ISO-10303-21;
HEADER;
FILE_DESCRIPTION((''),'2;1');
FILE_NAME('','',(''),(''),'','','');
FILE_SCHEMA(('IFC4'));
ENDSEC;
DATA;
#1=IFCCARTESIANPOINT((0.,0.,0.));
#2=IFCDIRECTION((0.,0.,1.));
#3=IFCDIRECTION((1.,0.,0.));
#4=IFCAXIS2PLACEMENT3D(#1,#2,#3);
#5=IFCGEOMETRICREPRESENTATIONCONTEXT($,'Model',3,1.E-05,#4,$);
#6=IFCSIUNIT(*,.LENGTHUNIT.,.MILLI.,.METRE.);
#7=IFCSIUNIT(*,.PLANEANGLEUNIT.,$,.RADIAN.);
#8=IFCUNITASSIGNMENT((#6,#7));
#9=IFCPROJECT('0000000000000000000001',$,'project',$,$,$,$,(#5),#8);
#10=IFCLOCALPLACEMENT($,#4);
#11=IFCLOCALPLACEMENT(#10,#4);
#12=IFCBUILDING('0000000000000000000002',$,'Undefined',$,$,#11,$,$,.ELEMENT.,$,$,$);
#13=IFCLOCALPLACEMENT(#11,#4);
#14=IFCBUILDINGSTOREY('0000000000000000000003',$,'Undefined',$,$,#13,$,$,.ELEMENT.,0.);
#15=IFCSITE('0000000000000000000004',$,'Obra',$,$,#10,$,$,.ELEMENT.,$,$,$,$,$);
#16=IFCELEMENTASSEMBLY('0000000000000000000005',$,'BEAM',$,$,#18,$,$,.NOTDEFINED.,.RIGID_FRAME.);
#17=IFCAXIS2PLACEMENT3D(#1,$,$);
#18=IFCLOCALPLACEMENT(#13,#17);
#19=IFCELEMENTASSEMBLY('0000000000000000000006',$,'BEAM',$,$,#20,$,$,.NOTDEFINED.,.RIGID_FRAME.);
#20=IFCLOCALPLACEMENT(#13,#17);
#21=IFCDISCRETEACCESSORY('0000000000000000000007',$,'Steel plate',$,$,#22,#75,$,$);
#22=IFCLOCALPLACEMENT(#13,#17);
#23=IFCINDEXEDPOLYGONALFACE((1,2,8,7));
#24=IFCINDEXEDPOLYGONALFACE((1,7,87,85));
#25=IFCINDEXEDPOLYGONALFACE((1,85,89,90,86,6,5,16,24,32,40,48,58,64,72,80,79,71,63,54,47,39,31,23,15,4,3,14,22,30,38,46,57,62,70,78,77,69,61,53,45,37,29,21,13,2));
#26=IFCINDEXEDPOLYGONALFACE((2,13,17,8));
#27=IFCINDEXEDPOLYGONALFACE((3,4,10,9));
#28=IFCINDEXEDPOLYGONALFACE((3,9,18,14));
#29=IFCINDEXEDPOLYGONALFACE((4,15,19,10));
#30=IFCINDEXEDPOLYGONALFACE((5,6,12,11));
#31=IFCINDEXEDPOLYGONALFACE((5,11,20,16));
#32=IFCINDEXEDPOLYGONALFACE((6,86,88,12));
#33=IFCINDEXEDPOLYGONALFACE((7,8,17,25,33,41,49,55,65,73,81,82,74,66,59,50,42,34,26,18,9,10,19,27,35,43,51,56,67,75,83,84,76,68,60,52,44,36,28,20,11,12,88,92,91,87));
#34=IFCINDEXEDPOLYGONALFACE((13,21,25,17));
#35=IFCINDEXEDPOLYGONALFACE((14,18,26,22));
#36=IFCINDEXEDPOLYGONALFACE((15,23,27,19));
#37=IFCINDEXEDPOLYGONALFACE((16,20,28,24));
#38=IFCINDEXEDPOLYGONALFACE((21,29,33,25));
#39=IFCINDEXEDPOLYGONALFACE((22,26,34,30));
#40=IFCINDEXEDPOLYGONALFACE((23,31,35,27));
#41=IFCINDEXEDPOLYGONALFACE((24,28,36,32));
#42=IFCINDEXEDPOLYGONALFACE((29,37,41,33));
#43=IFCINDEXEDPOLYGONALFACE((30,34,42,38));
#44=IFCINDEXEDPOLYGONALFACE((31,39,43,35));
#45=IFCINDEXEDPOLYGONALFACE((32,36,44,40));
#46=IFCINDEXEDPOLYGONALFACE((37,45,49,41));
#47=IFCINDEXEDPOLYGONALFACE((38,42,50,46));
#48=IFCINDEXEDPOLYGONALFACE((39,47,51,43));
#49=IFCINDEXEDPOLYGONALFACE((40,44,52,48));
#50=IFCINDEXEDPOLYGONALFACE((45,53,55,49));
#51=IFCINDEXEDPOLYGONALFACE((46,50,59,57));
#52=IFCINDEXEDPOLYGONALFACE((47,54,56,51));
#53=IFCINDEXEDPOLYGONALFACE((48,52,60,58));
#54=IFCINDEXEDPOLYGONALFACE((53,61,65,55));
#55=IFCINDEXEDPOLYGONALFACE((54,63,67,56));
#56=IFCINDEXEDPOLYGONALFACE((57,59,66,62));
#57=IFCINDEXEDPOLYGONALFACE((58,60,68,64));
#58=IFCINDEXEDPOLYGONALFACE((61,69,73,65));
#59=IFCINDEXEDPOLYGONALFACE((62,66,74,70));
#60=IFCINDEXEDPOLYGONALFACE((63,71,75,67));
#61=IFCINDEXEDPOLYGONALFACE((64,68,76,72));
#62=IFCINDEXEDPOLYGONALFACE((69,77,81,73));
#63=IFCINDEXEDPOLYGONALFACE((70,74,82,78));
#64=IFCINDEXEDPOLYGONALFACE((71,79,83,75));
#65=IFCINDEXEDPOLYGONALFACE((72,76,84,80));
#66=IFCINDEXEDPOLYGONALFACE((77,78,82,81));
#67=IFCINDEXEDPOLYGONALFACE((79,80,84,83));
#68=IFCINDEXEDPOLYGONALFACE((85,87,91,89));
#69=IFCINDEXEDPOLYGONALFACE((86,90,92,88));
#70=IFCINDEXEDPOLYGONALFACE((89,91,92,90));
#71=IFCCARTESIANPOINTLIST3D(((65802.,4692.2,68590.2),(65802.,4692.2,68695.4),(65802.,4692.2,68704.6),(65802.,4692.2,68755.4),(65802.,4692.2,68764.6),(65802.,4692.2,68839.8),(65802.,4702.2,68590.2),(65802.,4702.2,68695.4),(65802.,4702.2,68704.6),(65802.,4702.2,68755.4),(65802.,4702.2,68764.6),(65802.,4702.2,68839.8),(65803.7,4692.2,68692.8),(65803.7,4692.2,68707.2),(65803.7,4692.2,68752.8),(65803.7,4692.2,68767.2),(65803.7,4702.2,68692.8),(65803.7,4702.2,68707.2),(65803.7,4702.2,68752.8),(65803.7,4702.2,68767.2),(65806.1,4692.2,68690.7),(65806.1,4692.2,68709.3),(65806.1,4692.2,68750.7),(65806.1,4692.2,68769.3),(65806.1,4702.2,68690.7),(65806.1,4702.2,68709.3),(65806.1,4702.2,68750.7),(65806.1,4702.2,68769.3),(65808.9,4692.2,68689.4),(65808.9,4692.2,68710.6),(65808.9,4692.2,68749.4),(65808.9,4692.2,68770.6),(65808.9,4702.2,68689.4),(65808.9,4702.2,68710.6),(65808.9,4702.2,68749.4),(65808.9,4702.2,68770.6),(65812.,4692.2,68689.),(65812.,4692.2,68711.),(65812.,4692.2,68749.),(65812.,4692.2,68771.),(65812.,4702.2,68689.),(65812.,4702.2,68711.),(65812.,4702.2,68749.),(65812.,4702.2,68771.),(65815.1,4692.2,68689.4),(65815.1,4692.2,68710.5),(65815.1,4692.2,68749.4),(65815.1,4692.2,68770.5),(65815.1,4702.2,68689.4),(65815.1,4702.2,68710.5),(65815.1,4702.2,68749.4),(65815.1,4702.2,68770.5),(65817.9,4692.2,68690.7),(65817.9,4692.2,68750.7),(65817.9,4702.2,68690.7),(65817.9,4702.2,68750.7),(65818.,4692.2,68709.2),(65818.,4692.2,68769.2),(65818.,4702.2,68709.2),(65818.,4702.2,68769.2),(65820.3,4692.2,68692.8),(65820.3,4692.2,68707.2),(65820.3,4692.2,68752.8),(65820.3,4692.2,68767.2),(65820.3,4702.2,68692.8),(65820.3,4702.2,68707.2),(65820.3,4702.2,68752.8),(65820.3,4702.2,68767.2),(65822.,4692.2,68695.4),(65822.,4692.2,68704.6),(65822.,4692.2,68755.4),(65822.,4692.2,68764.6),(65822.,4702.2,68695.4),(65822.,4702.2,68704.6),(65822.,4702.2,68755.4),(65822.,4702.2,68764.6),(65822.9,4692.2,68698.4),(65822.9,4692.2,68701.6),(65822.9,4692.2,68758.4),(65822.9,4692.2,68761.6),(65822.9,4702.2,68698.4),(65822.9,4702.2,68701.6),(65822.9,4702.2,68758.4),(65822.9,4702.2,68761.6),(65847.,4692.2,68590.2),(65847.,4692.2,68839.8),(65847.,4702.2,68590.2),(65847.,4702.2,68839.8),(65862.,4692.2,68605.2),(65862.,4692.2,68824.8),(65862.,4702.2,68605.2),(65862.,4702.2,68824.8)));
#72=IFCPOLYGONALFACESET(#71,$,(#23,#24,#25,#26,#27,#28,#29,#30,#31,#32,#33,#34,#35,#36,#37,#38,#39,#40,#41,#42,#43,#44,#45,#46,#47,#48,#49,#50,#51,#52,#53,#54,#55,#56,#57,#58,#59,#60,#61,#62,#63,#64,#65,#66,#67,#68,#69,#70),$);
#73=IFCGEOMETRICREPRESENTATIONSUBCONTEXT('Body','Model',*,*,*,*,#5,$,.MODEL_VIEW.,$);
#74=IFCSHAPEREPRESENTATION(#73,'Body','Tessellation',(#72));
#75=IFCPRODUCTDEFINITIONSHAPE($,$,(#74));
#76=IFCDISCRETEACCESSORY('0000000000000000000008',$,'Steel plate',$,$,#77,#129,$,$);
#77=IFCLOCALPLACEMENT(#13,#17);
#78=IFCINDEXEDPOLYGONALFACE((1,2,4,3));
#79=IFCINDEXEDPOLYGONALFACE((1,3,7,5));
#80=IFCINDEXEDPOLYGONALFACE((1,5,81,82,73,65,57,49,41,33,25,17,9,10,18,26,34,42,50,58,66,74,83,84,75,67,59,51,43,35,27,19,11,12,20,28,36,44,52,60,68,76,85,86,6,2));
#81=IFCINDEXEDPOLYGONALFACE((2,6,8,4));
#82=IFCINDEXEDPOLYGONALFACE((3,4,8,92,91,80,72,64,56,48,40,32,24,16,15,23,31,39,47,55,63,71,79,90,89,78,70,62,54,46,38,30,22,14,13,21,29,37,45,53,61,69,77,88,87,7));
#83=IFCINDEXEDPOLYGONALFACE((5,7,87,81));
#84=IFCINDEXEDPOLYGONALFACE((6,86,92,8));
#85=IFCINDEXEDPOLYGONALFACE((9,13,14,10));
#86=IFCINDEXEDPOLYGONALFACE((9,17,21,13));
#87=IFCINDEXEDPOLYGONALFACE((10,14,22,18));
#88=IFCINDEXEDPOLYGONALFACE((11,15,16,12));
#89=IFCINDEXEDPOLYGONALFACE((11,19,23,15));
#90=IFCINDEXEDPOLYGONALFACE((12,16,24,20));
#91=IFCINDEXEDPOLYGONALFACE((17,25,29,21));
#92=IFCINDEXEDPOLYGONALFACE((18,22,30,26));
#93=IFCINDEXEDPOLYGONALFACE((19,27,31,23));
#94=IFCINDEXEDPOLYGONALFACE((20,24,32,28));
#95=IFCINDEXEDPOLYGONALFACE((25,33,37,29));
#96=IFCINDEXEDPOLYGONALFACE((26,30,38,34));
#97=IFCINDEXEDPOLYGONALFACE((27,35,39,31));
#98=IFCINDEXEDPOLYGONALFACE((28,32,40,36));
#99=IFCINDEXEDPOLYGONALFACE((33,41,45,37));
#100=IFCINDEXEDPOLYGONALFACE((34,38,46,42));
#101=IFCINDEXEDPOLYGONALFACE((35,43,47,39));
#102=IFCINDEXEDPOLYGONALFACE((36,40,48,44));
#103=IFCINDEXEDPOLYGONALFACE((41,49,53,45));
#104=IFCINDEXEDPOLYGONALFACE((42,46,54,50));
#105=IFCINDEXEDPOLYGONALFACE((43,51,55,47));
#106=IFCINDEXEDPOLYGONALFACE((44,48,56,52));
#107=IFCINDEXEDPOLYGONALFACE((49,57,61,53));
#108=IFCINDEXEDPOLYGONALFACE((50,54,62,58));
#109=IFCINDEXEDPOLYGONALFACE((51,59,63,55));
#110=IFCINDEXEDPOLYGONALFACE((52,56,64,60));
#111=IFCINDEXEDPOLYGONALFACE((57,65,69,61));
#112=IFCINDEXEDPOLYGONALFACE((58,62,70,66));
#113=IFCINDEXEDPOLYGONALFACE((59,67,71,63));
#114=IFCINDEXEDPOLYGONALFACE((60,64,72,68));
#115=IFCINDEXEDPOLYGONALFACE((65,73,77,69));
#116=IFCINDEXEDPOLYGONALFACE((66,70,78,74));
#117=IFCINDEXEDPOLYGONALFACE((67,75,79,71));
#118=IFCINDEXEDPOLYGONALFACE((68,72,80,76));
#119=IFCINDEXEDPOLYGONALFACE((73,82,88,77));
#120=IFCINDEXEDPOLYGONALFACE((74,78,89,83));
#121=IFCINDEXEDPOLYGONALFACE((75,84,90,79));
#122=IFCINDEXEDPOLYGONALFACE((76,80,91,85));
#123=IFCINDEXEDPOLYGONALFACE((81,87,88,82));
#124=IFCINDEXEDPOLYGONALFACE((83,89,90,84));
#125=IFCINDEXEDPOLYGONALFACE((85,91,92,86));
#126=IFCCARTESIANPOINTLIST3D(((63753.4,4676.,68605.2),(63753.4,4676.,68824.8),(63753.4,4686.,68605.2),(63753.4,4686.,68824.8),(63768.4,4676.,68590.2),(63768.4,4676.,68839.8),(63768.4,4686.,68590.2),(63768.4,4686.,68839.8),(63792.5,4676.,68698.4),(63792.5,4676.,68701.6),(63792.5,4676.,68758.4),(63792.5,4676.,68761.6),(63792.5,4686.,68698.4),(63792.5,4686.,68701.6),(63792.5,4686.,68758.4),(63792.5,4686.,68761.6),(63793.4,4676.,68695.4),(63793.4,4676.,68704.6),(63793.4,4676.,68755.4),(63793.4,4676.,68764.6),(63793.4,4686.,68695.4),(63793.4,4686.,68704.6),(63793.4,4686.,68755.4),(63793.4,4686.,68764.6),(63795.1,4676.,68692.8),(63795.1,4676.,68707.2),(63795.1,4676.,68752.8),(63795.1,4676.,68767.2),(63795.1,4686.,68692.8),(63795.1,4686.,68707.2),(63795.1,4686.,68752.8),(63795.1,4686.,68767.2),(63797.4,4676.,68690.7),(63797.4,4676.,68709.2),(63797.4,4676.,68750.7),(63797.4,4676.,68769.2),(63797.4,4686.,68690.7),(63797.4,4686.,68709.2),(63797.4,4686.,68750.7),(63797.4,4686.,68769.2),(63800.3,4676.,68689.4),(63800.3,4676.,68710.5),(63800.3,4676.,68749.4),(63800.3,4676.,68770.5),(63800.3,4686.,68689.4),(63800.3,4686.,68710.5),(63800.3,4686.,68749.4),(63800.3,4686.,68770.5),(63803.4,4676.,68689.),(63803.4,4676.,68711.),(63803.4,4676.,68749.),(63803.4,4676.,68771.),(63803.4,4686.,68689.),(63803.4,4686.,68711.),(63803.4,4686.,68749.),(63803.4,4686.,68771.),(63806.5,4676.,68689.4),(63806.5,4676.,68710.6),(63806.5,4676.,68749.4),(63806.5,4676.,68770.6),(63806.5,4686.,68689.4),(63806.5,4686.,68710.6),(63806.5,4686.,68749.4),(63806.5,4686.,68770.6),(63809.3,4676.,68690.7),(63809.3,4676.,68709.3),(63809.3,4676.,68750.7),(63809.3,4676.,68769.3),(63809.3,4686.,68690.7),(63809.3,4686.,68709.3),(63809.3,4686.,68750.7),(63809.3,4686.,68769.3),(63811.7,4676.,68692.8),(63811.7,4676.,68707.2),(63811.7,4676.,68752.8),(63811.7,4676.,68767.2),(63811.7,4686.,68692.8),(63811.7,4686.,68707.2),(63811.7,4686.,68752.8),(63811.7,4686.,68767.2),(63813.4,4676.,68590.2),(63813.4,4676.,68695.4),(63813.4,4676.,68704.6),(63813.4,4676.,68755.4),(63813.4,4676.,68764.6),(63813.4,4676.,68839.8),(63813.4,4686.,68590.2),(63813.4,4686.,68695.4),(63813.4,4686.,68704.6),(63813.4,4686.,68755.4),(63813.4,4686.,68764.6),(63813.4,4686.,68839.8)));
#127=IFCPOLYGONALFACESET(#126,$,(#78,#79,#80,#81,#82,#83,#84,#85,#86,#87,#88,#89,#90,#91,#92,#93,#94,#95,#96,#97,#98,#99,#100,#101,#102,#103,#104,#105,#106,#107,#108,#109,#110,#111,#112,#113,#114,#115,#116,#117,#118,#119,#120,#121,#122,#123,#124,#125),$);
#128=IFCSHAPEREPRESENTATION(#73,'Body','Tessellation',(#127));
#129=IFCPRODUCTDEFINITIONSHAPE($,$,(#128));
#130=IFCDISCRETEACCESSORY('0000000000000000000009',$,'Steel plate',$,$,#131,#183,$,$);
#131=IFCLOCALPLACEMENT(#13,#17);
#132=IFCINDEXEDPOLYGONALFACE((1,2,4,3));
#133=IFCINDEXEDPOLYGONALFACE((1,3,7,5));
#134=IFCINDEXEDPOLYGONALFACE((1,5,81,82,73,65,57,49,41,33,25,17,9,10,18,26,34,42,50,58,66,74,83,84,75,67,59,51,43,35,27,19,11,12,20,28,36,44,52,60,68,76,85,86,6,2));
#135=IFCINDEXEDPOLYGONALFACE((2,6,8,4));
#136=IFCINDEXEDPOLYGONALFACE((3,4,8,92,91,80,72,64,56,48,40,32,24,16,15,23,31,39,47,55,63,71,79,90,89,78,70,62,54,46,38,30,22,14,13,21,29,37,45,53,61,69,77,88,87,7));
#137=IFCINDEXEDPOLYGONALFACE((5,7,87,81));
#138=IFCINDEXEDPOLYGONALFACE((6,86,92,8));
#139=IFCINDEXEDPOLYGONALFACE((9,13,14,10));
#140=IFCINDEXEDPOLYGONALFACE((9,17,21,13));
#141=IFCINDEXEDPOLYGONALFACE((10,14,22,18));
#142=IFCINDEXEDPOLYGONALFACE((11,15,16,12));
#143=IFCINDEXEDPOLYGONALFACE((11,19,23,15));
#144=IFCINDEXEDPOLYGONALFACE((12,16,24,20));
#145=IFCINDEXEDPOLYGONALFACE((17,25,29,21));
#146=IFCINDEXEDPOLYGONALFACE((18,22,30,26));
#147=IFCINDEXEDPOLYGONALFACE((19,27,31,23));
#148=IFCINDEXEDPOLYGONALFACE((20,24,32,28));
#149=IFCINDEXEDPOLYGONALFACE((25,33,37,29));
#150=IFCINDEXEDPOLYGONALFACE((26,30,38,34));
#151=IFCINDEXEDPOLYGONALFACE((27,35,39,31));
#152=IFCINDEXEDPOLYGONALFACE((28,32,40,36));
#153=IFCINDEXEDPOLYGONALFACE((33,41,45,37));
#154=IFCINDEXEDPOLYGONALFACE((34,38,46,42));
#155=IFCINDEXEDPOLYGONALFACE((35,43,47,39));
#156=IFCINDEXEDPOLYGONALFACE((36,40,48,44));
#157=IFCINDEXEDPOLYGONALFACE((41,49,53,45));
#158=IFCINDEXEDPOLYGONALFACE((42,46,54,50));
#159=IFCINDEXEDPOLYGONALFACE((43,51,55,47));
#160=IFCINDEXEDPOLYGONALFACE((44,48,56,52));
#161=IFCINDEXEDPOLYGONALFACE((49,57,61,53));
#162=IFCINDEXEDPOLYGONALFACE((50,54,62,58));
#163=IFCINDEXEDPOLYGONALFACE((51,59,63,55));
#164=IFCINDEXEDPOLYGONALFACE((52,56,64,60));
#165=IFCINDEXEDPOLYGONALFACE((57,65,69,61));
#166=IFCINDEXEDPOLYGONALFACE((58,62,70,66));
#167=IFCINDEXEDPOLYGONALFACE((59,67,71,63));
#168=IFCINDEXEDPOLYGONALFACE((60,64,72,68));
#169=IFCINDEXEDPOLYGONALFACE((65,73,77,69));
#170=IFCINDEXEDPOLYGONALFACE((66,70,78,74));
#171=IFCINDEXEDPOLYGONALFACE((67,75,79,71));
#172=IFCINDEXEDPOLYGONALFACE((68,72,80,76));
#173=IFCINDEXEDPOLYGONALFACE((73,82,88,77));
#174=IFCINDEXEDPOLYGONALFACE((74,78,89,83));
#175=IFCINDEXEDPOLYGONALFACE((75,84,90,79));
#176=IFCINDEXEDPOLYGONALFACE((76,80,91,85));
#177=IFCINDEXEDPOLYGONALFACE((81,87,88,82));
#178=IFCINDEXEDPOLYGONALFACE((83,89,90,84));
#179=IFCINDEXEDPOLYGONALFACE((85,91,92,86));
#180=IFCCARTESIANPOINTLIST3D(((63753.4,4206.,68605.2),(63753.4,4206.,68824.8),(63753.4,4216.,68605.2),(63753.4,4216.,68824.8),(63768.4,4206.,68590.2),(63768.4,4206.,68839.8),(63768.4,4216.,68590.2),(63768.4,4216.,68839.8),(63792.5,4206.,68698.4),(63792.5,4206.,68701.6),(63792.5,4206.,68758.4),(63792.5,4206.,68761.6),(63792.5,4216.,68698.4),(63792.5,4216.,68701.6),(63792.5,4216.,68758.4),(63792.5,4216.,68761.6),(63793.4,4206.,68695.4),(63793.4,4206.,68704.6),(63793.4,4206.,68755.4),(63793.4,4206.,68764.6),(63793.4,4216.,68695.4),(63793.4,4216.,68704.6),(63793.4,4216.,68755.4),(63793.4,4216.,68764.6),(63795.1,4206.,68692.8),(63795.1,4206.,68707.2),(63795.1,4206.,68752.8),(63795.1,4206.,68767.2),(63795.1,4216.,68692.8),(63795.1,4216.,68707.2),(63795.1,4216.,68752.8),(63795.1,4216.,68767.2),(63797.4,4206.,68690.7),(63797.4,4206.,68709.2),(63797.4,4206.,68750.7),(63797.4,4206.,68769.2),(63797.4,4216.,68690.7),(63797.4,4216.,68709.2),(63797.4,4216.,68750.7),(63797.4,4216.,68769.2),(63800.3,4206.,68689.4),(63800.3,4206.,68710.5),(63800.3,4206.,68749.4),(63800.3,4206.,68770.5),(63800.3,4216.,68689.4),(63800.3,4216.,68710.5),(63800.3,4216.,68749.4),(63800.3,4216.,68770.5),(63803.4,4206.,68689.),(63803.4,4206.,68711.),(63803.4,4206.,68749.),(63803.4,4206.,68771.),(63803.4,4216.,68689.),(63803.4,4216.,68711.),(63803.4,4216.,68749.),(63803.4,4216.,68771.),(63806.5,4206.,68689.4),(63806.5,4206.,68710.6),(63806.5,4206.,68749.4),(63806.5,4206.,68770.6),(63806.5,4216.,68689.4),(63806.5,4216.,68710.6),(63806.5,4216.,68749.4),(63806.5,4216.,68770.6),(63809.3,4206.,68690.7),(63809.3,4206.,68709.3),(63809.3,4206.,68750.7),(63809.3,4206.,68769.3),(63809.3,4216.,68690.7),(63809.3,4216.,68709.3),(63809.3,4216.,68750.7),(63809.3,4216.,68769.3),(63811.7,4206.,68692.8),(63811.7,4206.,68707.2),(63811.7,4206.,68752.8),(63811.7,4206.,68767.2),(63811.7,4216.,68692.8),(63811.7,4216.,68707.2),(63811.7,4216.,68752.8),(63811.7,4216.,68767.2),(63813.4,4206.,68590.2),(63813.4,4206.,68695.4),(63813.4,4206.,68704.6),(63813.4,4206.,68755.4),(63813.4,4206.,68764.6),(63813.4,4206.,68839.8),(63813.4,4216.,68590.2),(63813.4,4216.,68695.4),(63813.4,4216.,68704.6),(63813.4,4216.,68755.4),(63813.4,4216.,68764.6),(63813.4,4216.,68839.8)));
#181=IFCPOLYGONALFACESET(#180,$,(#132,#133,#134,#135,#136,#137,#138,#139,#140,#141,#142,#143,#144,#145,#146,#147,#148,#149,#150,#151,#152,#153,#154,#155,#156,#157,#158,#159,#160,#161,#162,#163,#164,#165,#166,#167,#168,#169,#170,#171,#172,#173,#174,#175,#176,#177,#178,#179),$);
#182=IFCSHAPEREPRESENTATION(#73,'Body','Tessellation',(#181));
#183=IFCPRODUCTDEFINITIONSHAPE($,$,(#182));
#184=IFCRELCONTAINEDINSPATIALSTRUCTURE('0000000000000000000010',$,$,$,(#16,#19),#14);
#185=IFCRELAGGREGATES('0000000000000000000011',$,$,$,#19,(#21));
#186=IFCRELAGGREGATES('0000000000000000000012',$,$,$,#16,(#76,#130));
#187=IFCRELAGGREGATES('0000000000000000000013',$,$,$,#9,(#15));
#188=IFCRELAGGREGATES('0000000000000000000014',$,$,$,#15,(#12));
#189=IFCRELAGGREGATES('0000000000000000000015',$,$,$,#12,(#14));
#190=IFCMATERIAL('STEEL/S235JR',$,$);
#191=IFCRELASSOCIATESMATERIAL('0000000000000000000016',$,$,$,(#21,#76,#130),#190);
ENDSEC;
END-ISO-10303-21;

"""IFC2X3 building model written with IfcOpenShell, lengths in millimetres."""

from ifc_helpers import new_model, si_unit, frame, origin_with_axes, origin_2d_with_axis, place, context, subcontext, project, spatial, polyline, circle, outline, extrude, source, transform, mapped, material, element, aggregate, save


model = new_model("IFC2X3")

# Units and contexts
model_context = context("Model", 3, precision=1e-05, world=origin_with_axes())
body_context = subcontext(model_context, "Body", "Model", "MODEL_VIEW")
ifc_project = project(units=[si_unit("LENGTHUNIT", "METRE", prefix="MILLI"), si_unit("PLANEANGLEUNIT", "RADIAN")], contexts=[model_context])

# Site, building, storey
site_placement = place(None, origin_with_axes())
site = spatial("IfcSite", under=ifc_project, at=site_placement, Name="Obra", CompositionType="ELEMENT")
building_placement = place(site_placement, origin_with_axes())
building = spatial("IfcBuilding", under=site, at=building_placement, Name="Undefined", CompositionType="ELEMENT")
storey_placement = place(building_placement, origin_with_axes())
storey = spatial("IfcBuildingStorey", under=building, at=storey_placement, Name="Undefined", CompositionType="ELEMENT", Elevation=0.0)

# Shared definitions
ifc_material = material(Name="STEEL/S235JR")

# Element assembly
assembly_1_placement = place(storey_placement, origin_with_axes())
assembly_1 = element("IfcElementAssembly", 1, at=assembly_1_placement, inside=storey, Name="BEAM", AssemblyPlace="NOTDEFINED", PredefinedType="RIGID_FRAME")

# Shared definitions
shared_shape_1 = source(origin_with_axes(), body_context, "Body", "SweptSolid", [
    extrude(circle(Radius=11.0, at=origin_2d_with_axis()), frame((0.0, -13.2, 0.0), z_axis=(0.0, 1.0, 0.0), x_axis=(1.0, 0.0, 0.0)), (0.0, 0.0, 1.0), 10.2),
])

# Element assembly, discrete accessory, opening
assembly_2_placement = place(storey_placement, origin_with_axes())
assembly_2 = element("IfcElementAssembly", 2, at=assembly_2_placement, inside=storey, Name="BEAM", AssemblyPlace="NOTDEFINED", PredefinedType="RIGID_FRAME")
discrete_accessory_1_placement = place(assembly_2_placement, frame((65802.0, 4697.2, 68590.2), z_axis=(0.0, -1.0, 0.0), x_axis=(1.0, 0.0, 0.0)))
discrete_accessory_1 = element("IfcDiscreteAccessory", 3, at=discrete_accessory_1_placement, material=ifc_material, Name="Steel plate", context=body_context, shape_type="SweptSolid", body=[
    extrude(outline(polyline([(0.0, 0.0), (45.0, 0.0), (60.0, 15.0), (60.0, 234.6), (45.0, 249.6), (0.0, 249.6), (0.0, 0.0)])), frame((0.0, 0.0, -5.0), z_axis=(0.0, 0.0, 1.0), x_axis=(1.0, 0.0, 0.0)), (0.0, 0.0, 1.0), 10.0),
])
opening_1_placement = place(assembly_2_placement, frame((65852.0, 4689.1, 68850.0), z_axis=(-1.0, 0.0, 0.0), x_axis=(0.0, 0.0, -1.0)))
element("IfcOpeningElement", 4, at=opening_1_placement, cuts=discrete_accessory_1, ObjectType="Opening", context=body_context, shape_type="MappedRepresentation", body=[
    mapped(shared_shape_1, transform((90.0, 0.0, 40.0))),
    mapped(shared_shape_1, transform((150.0, 0.0, 40.0))),
])
aggregate(assembly_2, [discrete_accessory_1])

# Discrete accessories, openings
discrete_accessory_2_placement = place(assembly_1_placement, frame((63813.4, 4681.0, 68590.2), z_axis=(0.0, 1.0, 0.0), x_axis=(-1.0, 0.0, 0.0)))
discrete_accessory_2 = element("IfcDiscreteAccessory", 5, at=discrete_accessory_2_placement, material=ifc_material, Name="Steel plate", context=body_context, shape_type="SweptSolid", body=[
    extrude(outline(polyline([(0.0, 0.0), (45.0, 0.0), (60.0, 15.0), (60.0, 234.6), (45.0, 249.6), (0.0, 249.6), (0.0, 0.0)])), frame((0.0, 0.0, -5.0), z_axis=(0.0, 0.0, 1.0), x_axis=(1.0, 0.0, 0.0)), (0.0, 0.0, 1.0), 10.0),
])
opening_2_placement = place(assembly_1_placement, frame((63763.4, 4689.1, 68850.0), z_axis=(1.0, 0.0, 0.0), x_axis=(0.0, 0.0, -1.0)))
element("IfcOpeningElement", 6, at=opening_2_placement, cuts=discrete_accessory_2, ObjectType="Opening", context=body_context, shape_type="MappedRepresentation", body=[
    mapped(shared_shape_1, transform((90.0, 0.0, 40.0))),
    mapped(shared_shape_1, transform((150.0, 0.0, 40.0))),
])
discrete_accessory_3_placement = place(assembly_1_placement, frame((63813.4, 4211.0, 68590.2), z_axis=(0.0, 1.0, 0.0), x_axis=(-1.0, 0.0, 0.0)))
discrete_accessory_3 = element("IfcDiscreteAccessory", 7, at=discrete_accessory_3_placement, material=ifc_material, Name="Steel plate", context=body_context, shape_type="SweptSolid", body=[
    extrude(outline(polyline([(0.0, 0.0), (45.0, 0.0), (60.0, 15.0), (60.0, 234.6), (45.0, 249.6), (0.0, 249.6), (0.0, 0.0)])), frame((0.0, 0.0, -5.0), z_axis=(0.0, 0.0, 1.0), x_axis=(1.0, 0.0, 0.0)), (0.0, 0.0, 1.0), 10.0),
])
opening_3_placement = place(assembly_1_placement, frame((63763.4, 4219.1, 68850.0), z_axis=(1.0, 0.0, 0.0), x_axis=(0.0, 0.0, -1.0)))
element("IfcOpeningElement", 8, at=opening_3_placement, cuts=discrete_accessory_3, ObjectType="Opening", context=body_context, shape_type="MappedRepresentation", body=[
    mapped(shared_shape_1, transform((90.0, 0.0, 40.0))),
    mapped(shared_shape_1, transform((150.0, 0.0, 40.0))),
])
aggregate(assembly_1, [discrete_accessory_2, discrete_accessory_3])

save(model, "model.ifc")
